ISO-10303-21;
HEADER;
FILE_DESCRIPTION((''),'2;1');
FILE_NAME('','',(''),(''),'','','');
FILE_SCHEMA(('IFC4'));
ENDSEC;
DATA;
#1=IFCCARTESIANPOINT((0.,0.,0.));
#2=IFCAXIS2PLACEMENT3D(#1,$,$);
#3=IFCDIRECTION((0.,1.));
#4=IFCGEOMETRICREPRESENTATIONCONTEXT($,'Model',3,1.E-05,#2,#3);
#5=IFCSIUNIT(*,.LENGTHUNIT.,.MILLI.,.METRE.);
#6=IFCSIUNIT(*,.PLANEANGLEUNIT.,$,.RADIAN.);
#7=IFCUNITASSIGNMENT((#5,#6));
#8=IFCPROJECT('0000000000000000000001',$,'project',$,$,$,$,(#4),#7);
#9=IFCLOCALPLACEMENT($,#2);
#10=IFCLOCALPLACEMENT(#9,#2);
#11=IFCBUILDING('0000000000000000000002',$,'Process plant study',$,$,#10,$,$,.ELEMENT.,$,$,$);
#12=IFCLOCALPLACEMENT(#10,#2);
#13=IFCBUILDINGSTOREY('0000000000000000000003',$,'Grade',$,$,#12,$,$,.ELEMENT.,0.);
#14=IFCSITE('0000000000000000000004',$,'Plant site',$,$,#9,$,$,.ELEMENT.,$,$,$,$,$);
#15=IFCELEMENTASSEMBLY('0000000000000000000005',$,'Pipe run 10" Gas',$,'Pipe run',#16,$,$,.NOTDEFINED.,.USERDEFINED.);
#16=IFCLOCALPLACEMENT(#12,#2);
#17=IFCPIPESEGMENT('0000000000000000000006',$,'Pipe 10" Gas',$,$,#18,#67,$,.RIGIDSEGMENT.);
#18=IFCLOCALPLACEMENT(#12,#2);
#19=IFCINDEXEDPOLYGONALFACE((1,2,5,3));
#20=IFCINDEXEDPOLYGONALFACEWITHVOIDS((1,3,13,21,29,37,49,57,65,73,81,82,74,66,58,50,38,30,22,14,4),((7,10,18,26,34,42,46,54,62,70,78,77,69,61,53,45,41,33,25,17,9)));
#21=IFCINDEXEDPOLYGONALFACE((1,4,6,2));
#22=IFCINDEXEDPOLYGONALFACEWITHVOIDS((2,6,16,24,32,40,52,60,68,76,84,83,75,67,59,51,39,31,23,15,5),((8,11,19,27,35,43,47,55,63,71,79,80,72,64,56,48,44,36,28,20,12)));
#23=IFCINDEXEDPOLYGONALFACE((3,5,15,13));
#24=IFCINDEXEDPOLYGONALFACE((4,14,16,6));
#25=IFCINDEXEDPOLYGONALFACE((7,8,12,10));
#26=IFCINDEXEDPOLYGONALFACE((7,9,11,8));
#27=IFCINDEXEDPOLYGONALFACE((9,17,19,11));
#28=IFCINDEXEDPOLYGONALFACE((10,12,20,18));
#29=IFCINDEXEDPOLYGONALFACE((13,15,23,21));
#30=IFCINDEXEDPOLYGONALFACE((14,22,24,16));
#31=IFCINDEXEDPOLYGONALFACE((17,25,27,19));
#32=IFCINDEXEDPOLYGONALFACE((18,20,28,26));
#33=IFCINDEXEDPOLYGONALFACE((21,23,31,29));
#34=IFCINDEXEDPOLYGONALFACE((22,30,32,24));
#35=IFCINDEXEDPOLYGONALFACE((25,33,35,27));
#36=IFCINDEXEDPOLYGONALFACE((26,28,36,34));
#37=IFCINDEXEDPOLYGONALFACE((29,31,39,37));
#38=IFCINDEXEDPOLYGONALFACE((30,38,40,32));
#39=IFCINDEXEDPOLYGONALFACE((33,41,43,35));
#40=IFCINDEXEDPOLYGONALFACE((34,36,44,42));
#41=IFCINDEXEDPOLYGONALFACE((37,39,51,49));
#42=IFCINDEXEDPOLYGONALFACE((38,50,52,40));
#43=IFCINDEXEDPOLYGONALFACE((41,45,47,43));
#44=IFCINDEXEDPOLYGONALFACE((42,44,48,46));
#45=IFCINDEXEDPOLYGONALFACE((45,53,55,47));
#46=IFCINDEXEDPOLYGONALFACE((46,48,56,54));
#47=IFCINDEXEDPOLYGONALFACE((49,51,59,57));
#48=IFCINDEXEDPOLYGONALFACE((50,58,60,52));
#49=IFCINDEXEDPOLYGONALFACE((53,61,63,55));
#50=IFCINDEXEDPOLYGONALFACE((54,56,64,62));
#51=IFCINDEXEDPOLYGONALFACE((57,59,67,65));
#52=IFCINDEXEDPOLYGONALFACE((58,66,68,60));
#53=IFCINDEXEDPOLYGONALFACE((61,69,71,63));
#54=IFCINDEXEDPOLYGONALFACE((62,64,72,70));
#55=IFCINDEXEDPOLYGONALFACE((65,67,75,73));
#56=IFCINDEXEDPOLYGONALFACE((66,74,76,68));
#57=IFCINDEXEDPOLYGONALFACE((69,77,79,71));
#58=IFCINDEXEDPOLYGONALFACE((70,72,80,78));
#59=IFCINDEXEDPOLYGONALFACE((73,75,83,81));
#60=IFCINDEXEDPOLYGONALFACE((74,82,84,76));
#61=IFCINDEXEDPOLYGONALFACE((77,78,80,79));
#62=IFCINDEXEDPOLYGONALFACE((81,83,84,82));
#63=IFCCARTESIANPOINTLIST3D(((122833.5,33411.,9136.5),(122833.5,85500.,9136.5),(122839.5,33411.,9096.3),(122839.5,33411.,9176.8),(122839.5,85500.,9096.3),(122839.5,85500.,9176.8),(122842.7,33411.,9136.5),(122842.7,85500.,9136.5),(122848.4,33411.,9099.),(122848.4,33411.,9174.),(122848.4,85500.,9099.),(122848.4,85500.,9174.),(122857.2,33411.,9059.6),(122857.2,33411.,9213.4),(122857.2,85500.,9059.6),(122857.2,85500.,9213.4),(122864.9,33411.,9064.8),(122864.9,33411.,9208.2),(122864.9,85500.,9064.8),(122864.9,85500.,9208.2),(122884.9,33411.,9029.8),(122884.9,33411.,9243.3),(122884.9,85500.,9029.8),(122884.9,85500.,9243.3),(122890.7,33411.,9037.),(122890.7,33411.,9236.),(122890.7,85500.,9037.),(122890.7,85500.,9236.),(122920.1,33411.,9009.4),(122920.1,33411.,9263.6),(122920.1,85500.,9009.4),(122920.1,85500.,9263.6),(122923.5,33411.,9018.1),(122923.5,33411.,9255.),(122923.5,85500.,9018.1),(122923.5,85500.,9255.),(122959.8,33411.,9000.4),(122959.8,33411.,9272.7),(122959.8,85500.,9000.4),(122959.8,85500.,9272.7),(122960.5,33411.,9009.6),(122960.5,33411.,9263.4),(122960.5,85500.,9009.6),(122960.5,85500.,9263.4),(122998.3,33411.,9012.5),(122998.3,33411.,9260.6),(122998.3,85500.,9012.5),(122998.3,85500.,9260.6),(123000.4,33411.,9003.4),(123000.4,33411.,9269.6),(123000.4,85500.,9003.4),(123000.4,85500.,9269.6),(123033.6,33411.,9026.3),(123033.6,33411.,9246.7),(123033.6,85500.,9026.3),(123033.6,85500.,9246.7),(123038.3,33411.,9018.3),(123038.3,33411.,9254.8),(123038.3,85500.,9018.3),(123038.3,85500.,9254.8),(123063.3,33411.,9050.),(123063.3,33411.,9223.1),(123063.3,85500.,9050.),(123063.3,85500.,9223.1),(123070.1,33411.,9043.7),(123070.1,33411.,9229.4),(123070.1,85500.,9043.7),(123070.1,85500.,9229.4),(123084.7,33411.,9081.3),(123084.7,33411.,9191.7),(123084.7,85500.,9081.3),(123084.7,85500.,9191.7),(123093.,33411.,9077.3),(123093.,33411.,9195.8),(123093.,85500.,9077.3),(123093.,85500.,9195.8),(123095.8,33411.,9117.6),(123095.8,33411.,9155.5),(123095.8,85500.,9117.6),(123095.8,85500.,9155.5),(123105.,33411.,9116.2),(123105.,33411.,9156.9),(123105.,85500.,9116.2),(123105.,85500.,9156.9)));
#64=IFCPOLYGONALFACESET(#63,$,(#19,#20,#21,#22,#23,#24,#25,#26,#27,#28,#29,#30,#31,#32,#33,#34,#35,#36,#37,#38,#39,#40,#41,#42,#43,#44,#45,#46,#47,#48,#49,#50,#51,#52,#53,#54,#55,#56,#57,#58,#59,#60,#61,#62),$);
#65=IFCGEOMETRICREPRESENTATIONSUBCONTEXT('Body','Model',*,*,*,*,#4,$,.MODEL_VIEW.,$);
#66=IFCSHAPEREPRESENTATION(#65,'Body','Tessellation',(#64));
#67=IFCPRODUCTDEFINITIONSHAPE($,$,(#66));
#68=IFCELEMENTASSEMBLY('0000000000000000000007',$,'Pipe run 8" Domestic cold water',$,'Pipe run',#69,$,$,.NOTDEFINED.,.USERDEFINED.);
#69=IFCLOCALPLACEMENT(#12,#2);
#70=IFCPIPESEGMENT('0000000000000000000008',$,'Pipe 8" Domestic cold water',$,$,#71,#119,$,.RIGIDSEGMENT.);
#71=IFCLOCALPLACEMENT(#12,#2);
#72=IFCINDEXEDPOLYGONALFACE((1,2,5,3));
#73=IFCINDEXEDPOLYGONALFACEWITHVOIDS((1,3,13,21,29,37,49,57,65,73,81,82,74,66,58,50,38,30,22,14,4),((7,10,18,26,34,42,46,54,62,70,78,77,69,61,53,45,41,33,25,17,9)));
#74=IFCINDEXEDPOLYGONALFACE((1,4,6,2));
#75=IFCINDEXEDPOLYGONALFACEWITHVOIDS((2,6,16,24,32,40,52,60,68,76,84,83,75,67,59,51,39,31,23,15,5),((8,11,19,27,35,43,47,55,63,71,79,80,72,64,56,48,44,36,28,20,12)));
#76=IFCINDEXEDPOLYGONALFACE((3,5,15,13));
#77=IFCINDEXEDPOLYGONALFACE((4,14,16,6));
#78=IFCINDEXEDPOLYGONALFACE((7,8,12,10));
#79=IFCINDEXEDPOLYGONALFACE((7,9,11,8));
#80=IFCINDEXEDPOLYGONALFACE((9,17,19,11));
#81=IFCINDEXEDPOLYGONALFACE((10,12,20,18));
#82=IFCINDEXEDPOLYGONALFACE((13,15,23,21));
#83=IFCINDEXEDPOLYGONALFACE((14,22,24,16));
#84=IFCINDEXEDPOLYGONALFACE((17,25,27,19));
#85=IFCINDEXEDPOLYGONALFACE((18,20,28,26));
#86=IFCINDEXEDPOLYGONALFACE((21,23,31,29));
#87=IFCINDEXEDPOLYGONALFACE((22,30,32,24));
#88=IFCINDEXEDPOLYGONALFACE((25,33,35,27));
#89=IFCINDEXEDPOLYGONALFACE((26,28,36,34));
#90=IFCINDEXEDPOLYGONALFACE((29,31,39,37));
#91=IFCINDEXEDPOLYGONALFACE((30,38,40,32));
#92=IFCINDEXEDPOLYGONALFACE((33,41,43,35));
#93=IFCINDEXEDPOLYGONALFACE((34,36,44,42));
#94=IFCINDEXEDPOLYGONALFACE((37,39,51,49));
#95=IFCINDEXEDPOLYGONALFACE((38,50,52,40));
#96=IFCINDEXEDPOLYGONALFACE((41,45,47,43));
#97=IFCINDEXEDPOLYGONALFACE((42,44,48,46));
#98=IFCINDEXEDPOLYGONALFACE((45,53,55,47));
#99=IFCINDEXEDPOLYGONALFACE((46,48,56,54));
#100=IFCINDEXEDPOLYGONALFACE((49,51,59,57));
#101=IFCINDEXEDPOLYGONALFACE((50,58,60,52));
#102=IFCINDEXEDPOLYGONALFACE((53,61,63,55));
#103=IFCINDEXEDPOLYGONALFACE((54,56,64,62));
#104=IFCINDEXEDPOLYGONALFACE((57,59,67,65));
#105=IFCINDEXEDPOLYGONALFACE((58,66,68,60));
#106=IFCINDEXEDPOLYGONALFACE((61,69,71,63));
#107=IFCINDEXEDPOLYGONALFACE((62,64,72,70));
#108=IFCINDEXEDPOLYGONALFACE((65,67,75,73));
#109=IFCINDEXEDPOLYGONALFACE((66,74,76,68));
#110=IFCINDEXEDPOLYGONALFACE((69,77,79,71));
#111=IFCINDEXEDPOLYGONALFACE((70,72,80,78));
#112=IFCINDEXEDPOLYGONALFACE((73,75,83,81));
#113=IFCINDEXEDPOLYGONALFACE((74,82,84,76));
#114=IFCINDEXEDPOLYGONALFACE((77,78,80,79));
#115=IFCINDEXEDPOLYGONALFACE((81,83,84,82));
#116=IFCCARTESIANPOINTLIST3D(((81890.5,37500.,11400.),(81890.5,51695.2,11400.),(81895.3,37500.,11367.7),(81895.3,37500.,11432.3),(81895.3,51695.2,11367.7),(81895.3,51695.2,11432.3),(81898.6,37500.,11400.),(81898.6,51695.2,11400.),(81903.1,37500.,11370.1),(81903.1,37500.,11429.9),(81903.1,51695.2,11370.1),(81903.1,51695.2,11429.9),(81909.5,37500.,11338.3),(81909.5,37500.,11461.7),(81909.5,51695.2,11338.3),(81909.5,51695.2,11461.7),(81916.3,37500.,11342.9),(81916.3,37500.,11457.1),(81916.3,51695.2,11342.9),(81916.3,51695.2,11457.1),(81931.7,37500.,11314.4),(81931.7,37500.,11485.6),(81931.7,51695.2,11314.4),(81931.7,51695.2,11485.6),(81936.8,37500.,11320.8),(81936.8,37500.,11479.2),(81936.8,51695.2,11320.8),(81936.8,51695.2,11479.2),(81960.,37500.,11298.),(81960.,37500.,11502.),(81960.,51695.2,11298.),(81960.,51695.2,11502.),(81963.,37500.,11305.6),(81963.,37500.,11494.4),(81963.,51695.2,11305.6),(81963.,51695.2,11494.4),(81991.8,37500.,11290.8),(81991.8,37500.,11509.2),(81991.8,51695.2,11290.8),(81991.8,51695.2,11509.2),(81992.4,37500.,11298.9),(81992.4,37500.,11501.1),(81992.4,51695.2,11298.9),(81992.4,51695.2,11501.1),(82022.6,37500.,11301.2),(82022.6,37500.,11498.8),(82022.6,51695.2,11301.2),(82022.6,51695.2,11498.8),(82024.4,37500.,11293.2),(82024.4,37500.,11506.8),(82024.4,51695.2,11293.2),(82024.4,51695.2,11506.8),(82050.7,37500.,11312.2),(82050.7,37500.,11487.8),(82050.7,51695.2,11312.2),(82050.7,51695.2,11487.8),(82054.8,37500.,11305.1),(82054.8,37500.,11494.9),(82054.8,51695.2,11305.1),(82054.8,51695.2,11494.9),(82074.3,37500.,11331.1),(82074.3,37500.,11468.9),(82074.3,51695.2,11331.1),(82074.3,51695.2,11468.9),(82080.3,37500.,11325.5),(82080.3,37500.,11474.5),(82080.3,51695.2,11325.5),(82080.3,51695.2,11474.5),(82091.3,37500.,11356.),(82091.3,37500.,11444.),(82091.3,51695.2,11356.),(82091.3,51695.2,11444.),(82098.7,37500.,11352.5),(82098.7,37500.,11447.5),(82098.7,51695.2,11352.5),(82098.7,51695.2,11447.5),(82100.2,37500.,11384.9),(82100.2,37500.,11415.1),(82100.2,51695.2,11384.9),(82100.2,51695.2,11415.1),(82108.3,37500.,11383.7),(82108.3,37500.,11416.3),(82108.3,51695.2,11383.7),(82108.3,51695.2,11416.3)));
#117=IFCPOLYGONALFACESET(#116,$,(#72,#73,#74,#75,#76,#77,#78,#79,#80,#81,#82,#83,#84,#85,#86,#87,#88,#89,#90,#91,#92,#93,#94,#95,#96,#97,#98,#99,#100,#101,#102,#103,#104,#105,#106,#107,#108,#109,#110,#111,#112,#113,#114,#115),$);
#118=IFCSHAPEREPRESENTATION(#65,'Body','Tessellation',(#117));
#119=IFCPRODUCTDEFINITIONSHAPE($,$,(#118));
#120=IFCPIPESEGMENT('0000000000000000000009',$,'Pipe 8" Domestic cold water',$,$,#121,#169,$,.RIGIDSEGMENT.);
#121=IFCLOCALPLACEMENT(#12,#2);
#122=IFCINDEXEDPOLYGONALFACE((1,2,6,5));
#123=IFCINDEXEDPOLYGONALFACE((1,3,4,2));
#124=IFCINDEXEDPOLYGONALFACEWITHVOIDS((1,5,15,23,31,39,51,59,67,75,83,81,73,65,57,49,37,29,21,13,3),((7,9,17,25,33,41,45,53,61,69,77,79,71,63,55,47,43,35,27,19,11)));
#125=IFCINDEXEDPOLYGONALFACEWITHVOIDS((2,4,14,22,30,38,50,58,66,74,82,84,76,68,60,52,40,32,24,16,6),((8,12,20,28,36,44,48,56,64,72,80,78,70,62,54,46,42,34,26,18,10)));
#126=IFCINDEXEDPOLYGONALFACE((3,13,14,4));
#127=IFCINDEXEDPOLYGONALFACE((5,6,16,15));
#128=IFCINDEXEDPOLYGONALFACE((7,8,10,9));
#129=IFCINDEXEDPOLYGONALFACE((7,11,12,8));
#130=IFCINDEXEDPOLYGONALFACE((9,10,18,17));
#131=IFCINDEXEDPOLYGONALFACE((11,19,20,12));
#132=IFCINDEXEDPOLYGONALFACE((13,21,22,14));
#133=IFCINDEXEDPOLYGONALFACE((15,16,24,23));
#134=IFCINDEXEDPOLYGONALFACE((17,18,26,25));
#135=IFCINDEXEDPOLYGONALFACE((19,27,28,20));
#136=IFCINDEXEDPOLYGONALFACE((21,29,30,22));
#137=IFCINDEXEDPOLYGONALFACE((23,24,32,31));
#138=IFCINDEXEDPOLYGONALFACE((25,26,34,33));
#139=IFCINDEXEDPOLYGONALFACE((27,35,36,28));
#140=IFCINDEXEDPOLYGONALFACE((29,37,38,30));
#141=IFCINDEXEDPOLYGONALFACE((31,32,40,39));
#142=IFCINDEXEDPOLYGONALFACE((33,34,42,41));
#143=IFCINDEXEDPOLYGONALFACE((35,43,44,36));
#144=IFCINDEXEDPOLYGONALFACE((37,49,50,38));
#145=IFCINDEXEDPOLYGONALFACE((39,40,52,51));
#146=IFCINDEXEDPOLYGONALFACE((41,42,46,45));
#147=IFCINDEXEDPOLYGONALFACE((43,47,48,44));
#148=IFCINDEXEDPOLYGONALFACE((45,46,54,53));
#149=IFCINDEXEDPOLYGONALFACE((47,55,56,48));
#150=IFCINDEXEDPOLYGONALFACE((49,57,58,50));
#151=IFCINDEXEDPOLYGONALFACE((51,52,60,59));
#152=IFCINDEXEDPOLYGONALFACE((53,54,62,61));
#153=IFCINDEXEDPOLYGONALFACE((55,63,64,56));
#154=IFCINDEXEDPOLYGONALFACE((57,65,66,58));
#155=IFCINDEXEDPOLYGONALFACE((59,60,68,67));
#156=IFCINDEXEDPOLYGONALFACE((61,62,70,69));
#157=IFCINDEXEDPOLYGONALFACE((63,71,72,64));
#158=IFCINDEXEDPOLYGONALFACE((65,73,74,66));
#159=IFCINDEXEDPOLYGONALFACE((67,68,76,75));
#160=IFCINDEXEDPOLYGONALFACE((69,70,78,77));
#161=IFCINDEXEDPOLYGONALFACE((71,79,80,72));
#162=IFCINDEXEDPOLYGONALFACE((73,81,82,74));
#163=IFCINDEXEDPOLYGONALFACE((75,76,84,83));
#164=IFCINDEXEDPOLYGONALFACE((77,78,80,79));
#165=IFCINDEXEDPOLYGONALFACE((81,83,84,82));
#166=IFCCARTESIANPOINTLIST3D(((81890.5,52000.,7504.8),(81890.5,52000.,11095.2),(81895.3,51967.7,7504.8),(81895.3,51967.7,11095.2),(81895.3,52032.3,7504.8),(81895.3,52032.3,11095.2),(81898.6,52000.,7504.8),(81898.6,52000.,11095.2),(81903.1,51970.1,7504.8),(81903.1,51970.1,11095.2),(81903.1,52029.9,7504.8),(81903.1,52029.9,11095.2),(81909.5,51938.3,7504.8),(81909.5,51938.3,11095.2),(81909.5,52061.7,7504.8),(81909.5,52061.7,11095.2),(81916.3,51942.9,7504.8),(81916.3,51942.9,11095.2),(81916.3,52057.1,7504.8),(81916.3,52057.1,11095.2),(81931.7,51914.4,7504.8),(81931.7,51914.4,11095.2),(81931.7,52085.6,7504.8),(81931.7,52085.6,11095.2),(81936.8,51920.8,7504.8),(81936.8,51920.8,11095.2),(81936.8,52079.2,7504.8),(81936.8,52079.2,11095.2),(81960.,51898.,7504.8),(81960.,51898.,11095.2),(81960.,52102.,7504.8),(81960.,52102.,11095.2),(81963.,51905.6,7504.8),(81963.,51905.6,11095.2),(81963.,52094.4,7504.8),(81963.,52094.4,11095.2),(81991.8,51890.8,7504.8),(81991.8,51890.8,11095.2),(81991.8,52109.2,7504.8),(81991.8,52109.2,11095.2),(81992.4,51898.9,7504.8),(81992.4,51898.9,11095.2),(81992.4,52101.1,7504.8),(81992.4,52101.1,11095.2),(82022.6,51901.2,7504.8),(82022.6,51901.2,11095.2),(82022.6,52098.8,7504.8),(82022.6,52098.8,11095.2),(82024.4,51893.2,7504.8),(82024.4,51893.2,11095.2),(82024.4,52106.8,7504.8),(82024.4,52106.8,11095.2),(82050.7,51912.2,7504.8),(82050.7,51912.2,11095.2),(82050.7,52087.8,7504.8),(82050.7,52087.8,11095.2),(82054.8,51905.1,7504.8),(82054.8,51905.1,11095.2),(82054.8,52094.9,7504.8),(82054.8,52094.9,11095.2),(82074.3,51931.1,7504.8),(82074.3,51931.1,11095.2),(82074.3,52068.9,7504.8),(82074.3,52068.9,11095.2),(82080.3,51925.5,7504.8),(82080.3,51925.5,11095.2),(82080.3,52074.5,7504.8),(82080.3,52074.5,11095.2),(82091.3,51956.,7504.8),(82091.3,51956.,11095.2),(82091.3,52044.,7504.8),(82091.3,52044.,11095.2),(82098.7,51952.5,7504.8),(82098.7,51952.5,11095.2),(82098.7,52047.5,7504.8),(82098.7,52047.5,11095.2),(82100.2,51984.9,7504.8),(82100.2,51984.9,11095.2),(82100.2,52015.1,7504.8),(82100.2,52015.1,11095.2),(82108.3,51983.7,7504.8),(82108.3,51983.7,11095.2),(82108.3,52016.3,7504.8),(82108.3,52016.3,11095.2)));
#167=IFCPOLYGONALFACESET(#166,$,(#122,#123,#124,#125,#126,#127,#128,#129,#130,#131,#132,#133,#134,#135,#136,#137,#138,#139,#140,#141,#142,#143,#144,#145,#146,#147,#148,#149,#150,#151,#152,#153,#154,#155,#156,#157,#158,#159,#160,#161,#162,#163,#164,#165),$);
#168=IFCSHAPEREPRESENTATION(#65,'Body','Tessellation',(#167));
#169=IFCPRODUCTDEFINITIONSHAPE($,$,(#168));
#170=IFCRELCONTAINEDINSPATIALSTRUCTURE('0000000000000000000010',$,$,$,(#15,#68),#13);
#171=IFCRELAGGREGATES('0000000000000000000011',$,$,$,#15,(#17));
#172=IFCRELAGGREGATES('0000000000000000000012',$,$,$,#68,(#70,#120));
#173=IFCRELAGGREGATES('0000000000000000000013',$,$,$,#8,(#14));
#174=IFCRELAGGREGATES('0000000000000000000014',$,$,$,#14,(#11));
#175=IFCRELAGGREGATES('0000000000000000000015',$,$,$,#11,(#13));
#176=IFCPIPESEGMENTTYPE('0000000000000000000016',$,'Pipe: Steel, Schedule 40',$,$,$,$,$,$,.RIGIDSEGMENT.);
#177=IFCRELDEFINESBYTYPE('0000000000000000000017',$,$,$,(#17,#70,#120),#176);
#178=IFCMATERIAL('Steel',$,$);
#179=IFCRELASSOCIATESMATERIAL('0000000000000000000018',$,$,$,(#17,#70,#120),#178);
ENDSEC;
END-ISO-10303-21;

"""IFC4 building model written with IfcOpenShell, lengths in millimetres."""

from ifc_helpers import new_model, si_unit, direction, frame, origin, origin_with_axes, origin_2d, place, context, subcontext, project, spatial, hollow_circle, extrude, material, type_object, element, aggregate, save


model = new_model("IFC4")

# Units and contexts
model_context = context("Model", 3, precision=1e-05, world=origin(), true_north=direction((0.0, 1.0)))
body_context = subcontext(model_context, "Body", "Model", "MODEL_VIEW")
ifc_project = project(units=[si_unit("LENGTHUNIT", "METRE", prefix="MILLI"), si_unit("PLANEANGLEUNIT", "RADIAN")], contexts=[model_context])

# Site, building, storey
site_placement = place(None, origin())
site = spatial("IfcSite", under=ifc_project, at=site_placement, Name="Plant site", CompositionType="ELEMENT")
building_placement = place(site_placement, origin())
building = spatial("IfcBuilding", under=site, at=building_placement, Name="Process plant study", CompositionType="ELEMENT")
storey_placement = place(building_placement, origin())
storey = spatial("IfcBuildingStorey", under=building, at=storey_placement, Name="Grade", CompositionType="ELEMENT", Elevation=0.0)

# Shared definitions
ifc_material = material(Name="Steel")
pipe_segment_type = type_object("IfcPipeSegmentType", Name="Pipe: Steel, Schedule 40", PredefinedType="RIGIDSEGMENT")

# Element assemblies, pipe segments
assembly_1_placement = place(storey_placement, origin_with_axes())
assembly_1 = element("IfcElementAssembly", 1, at=assembly_1_placement, inside=storey, Name="Pipe run 10\" Gas", ObjectType="Pipe run", AssemblyPlace="NOTDEFINED", PredefinedType="USERDEFINED")
pipe_segment_1_placement = place(storey_placement, origin_with_axes())
pipe_segment_1 = element("IfcPipeSegment", 2, at=pipe_segment_1_placement, type_object=pipe_segment_type, material=ifc_material, Name="Pipe 10\" Gas", PredefinedType="RIGIDSEGMENT", context=body_context, shape_type="SweptSolid", body=[
    extrude(hollow_circle(Radius=136.5, WallThickness=9.3, at=origin_2d()), frame((122970.0, 33411.0, 9136.5), z_axis=(0.0, 1.0, 0.0), x_axis=(-1.0, 0.0, 0.0)), (0.0, 0.0, 1.0), 52089.0),
])
assembly_2_placement = place(storey_placement, origin_with_axes())
assembly_2 = element("IfcElementAssembly", 3, at=assembly_2_placement, inside=storey, Name="Pipe run 8\" Domestic cold water", ObjectType="Pipe run", AssemblyPlace="NOTDEFINED", PredefinedType="USERDEFINED")
pipe_segment_2_placement = place(storey_placement, origin_with_axes())
pipe_segment_2 = element("IfcPipeSegment", 4, at=pipe_segment_2_placement, type_object=pipe_segment_type, material=ifc_material, Name="Pipe 8\" Domestic cold water", PredefinedType="RIGIDSEGMENT", context=body_context, shape_type="SweptSolid", body=[
    extrude(hollow_circle(Radius=109.5, WallThickness=8.2, at=origin_2d()), frame((82000.0, 37500.0, 11400.0), z_axis=(0.0, 1.0, 0.0), x_axis=(-1.0, 0.0, 0.0)), (0.0, 0.0, 1.0), 14195.2),
])
pipe_segment_3_placement = place(storey_placement, origin_with_axes())
pipe_segment_3 = element("IfcPipeSegment", 5, at=pipe_segment_3_placement, type_object=pipe_segment_type, material=ifc_material, Name="Pipe 8\" Domestic cold water", PredefinedType="RIGIDSEGMENT", context=body_context, shape_type="SweptSolid", body=[
    extrude(hollow_circle(Radius=109.5, WallThickness=8.2, at=origin_2d()), frame((82000.0, 52000.0, 11095.2), z_axis=(0.0, 0.0, -1.0), x_axis=(-1.0, 0.0, 0.0)), (0.0, 0.0, 1.0), 3590.4),
])

aggregate(assembly_1, [pipe_segment_1])
aggregate(assembly_2, [pipe_segment_2, pipe_segment_3])

save(model, "model.ifc")
